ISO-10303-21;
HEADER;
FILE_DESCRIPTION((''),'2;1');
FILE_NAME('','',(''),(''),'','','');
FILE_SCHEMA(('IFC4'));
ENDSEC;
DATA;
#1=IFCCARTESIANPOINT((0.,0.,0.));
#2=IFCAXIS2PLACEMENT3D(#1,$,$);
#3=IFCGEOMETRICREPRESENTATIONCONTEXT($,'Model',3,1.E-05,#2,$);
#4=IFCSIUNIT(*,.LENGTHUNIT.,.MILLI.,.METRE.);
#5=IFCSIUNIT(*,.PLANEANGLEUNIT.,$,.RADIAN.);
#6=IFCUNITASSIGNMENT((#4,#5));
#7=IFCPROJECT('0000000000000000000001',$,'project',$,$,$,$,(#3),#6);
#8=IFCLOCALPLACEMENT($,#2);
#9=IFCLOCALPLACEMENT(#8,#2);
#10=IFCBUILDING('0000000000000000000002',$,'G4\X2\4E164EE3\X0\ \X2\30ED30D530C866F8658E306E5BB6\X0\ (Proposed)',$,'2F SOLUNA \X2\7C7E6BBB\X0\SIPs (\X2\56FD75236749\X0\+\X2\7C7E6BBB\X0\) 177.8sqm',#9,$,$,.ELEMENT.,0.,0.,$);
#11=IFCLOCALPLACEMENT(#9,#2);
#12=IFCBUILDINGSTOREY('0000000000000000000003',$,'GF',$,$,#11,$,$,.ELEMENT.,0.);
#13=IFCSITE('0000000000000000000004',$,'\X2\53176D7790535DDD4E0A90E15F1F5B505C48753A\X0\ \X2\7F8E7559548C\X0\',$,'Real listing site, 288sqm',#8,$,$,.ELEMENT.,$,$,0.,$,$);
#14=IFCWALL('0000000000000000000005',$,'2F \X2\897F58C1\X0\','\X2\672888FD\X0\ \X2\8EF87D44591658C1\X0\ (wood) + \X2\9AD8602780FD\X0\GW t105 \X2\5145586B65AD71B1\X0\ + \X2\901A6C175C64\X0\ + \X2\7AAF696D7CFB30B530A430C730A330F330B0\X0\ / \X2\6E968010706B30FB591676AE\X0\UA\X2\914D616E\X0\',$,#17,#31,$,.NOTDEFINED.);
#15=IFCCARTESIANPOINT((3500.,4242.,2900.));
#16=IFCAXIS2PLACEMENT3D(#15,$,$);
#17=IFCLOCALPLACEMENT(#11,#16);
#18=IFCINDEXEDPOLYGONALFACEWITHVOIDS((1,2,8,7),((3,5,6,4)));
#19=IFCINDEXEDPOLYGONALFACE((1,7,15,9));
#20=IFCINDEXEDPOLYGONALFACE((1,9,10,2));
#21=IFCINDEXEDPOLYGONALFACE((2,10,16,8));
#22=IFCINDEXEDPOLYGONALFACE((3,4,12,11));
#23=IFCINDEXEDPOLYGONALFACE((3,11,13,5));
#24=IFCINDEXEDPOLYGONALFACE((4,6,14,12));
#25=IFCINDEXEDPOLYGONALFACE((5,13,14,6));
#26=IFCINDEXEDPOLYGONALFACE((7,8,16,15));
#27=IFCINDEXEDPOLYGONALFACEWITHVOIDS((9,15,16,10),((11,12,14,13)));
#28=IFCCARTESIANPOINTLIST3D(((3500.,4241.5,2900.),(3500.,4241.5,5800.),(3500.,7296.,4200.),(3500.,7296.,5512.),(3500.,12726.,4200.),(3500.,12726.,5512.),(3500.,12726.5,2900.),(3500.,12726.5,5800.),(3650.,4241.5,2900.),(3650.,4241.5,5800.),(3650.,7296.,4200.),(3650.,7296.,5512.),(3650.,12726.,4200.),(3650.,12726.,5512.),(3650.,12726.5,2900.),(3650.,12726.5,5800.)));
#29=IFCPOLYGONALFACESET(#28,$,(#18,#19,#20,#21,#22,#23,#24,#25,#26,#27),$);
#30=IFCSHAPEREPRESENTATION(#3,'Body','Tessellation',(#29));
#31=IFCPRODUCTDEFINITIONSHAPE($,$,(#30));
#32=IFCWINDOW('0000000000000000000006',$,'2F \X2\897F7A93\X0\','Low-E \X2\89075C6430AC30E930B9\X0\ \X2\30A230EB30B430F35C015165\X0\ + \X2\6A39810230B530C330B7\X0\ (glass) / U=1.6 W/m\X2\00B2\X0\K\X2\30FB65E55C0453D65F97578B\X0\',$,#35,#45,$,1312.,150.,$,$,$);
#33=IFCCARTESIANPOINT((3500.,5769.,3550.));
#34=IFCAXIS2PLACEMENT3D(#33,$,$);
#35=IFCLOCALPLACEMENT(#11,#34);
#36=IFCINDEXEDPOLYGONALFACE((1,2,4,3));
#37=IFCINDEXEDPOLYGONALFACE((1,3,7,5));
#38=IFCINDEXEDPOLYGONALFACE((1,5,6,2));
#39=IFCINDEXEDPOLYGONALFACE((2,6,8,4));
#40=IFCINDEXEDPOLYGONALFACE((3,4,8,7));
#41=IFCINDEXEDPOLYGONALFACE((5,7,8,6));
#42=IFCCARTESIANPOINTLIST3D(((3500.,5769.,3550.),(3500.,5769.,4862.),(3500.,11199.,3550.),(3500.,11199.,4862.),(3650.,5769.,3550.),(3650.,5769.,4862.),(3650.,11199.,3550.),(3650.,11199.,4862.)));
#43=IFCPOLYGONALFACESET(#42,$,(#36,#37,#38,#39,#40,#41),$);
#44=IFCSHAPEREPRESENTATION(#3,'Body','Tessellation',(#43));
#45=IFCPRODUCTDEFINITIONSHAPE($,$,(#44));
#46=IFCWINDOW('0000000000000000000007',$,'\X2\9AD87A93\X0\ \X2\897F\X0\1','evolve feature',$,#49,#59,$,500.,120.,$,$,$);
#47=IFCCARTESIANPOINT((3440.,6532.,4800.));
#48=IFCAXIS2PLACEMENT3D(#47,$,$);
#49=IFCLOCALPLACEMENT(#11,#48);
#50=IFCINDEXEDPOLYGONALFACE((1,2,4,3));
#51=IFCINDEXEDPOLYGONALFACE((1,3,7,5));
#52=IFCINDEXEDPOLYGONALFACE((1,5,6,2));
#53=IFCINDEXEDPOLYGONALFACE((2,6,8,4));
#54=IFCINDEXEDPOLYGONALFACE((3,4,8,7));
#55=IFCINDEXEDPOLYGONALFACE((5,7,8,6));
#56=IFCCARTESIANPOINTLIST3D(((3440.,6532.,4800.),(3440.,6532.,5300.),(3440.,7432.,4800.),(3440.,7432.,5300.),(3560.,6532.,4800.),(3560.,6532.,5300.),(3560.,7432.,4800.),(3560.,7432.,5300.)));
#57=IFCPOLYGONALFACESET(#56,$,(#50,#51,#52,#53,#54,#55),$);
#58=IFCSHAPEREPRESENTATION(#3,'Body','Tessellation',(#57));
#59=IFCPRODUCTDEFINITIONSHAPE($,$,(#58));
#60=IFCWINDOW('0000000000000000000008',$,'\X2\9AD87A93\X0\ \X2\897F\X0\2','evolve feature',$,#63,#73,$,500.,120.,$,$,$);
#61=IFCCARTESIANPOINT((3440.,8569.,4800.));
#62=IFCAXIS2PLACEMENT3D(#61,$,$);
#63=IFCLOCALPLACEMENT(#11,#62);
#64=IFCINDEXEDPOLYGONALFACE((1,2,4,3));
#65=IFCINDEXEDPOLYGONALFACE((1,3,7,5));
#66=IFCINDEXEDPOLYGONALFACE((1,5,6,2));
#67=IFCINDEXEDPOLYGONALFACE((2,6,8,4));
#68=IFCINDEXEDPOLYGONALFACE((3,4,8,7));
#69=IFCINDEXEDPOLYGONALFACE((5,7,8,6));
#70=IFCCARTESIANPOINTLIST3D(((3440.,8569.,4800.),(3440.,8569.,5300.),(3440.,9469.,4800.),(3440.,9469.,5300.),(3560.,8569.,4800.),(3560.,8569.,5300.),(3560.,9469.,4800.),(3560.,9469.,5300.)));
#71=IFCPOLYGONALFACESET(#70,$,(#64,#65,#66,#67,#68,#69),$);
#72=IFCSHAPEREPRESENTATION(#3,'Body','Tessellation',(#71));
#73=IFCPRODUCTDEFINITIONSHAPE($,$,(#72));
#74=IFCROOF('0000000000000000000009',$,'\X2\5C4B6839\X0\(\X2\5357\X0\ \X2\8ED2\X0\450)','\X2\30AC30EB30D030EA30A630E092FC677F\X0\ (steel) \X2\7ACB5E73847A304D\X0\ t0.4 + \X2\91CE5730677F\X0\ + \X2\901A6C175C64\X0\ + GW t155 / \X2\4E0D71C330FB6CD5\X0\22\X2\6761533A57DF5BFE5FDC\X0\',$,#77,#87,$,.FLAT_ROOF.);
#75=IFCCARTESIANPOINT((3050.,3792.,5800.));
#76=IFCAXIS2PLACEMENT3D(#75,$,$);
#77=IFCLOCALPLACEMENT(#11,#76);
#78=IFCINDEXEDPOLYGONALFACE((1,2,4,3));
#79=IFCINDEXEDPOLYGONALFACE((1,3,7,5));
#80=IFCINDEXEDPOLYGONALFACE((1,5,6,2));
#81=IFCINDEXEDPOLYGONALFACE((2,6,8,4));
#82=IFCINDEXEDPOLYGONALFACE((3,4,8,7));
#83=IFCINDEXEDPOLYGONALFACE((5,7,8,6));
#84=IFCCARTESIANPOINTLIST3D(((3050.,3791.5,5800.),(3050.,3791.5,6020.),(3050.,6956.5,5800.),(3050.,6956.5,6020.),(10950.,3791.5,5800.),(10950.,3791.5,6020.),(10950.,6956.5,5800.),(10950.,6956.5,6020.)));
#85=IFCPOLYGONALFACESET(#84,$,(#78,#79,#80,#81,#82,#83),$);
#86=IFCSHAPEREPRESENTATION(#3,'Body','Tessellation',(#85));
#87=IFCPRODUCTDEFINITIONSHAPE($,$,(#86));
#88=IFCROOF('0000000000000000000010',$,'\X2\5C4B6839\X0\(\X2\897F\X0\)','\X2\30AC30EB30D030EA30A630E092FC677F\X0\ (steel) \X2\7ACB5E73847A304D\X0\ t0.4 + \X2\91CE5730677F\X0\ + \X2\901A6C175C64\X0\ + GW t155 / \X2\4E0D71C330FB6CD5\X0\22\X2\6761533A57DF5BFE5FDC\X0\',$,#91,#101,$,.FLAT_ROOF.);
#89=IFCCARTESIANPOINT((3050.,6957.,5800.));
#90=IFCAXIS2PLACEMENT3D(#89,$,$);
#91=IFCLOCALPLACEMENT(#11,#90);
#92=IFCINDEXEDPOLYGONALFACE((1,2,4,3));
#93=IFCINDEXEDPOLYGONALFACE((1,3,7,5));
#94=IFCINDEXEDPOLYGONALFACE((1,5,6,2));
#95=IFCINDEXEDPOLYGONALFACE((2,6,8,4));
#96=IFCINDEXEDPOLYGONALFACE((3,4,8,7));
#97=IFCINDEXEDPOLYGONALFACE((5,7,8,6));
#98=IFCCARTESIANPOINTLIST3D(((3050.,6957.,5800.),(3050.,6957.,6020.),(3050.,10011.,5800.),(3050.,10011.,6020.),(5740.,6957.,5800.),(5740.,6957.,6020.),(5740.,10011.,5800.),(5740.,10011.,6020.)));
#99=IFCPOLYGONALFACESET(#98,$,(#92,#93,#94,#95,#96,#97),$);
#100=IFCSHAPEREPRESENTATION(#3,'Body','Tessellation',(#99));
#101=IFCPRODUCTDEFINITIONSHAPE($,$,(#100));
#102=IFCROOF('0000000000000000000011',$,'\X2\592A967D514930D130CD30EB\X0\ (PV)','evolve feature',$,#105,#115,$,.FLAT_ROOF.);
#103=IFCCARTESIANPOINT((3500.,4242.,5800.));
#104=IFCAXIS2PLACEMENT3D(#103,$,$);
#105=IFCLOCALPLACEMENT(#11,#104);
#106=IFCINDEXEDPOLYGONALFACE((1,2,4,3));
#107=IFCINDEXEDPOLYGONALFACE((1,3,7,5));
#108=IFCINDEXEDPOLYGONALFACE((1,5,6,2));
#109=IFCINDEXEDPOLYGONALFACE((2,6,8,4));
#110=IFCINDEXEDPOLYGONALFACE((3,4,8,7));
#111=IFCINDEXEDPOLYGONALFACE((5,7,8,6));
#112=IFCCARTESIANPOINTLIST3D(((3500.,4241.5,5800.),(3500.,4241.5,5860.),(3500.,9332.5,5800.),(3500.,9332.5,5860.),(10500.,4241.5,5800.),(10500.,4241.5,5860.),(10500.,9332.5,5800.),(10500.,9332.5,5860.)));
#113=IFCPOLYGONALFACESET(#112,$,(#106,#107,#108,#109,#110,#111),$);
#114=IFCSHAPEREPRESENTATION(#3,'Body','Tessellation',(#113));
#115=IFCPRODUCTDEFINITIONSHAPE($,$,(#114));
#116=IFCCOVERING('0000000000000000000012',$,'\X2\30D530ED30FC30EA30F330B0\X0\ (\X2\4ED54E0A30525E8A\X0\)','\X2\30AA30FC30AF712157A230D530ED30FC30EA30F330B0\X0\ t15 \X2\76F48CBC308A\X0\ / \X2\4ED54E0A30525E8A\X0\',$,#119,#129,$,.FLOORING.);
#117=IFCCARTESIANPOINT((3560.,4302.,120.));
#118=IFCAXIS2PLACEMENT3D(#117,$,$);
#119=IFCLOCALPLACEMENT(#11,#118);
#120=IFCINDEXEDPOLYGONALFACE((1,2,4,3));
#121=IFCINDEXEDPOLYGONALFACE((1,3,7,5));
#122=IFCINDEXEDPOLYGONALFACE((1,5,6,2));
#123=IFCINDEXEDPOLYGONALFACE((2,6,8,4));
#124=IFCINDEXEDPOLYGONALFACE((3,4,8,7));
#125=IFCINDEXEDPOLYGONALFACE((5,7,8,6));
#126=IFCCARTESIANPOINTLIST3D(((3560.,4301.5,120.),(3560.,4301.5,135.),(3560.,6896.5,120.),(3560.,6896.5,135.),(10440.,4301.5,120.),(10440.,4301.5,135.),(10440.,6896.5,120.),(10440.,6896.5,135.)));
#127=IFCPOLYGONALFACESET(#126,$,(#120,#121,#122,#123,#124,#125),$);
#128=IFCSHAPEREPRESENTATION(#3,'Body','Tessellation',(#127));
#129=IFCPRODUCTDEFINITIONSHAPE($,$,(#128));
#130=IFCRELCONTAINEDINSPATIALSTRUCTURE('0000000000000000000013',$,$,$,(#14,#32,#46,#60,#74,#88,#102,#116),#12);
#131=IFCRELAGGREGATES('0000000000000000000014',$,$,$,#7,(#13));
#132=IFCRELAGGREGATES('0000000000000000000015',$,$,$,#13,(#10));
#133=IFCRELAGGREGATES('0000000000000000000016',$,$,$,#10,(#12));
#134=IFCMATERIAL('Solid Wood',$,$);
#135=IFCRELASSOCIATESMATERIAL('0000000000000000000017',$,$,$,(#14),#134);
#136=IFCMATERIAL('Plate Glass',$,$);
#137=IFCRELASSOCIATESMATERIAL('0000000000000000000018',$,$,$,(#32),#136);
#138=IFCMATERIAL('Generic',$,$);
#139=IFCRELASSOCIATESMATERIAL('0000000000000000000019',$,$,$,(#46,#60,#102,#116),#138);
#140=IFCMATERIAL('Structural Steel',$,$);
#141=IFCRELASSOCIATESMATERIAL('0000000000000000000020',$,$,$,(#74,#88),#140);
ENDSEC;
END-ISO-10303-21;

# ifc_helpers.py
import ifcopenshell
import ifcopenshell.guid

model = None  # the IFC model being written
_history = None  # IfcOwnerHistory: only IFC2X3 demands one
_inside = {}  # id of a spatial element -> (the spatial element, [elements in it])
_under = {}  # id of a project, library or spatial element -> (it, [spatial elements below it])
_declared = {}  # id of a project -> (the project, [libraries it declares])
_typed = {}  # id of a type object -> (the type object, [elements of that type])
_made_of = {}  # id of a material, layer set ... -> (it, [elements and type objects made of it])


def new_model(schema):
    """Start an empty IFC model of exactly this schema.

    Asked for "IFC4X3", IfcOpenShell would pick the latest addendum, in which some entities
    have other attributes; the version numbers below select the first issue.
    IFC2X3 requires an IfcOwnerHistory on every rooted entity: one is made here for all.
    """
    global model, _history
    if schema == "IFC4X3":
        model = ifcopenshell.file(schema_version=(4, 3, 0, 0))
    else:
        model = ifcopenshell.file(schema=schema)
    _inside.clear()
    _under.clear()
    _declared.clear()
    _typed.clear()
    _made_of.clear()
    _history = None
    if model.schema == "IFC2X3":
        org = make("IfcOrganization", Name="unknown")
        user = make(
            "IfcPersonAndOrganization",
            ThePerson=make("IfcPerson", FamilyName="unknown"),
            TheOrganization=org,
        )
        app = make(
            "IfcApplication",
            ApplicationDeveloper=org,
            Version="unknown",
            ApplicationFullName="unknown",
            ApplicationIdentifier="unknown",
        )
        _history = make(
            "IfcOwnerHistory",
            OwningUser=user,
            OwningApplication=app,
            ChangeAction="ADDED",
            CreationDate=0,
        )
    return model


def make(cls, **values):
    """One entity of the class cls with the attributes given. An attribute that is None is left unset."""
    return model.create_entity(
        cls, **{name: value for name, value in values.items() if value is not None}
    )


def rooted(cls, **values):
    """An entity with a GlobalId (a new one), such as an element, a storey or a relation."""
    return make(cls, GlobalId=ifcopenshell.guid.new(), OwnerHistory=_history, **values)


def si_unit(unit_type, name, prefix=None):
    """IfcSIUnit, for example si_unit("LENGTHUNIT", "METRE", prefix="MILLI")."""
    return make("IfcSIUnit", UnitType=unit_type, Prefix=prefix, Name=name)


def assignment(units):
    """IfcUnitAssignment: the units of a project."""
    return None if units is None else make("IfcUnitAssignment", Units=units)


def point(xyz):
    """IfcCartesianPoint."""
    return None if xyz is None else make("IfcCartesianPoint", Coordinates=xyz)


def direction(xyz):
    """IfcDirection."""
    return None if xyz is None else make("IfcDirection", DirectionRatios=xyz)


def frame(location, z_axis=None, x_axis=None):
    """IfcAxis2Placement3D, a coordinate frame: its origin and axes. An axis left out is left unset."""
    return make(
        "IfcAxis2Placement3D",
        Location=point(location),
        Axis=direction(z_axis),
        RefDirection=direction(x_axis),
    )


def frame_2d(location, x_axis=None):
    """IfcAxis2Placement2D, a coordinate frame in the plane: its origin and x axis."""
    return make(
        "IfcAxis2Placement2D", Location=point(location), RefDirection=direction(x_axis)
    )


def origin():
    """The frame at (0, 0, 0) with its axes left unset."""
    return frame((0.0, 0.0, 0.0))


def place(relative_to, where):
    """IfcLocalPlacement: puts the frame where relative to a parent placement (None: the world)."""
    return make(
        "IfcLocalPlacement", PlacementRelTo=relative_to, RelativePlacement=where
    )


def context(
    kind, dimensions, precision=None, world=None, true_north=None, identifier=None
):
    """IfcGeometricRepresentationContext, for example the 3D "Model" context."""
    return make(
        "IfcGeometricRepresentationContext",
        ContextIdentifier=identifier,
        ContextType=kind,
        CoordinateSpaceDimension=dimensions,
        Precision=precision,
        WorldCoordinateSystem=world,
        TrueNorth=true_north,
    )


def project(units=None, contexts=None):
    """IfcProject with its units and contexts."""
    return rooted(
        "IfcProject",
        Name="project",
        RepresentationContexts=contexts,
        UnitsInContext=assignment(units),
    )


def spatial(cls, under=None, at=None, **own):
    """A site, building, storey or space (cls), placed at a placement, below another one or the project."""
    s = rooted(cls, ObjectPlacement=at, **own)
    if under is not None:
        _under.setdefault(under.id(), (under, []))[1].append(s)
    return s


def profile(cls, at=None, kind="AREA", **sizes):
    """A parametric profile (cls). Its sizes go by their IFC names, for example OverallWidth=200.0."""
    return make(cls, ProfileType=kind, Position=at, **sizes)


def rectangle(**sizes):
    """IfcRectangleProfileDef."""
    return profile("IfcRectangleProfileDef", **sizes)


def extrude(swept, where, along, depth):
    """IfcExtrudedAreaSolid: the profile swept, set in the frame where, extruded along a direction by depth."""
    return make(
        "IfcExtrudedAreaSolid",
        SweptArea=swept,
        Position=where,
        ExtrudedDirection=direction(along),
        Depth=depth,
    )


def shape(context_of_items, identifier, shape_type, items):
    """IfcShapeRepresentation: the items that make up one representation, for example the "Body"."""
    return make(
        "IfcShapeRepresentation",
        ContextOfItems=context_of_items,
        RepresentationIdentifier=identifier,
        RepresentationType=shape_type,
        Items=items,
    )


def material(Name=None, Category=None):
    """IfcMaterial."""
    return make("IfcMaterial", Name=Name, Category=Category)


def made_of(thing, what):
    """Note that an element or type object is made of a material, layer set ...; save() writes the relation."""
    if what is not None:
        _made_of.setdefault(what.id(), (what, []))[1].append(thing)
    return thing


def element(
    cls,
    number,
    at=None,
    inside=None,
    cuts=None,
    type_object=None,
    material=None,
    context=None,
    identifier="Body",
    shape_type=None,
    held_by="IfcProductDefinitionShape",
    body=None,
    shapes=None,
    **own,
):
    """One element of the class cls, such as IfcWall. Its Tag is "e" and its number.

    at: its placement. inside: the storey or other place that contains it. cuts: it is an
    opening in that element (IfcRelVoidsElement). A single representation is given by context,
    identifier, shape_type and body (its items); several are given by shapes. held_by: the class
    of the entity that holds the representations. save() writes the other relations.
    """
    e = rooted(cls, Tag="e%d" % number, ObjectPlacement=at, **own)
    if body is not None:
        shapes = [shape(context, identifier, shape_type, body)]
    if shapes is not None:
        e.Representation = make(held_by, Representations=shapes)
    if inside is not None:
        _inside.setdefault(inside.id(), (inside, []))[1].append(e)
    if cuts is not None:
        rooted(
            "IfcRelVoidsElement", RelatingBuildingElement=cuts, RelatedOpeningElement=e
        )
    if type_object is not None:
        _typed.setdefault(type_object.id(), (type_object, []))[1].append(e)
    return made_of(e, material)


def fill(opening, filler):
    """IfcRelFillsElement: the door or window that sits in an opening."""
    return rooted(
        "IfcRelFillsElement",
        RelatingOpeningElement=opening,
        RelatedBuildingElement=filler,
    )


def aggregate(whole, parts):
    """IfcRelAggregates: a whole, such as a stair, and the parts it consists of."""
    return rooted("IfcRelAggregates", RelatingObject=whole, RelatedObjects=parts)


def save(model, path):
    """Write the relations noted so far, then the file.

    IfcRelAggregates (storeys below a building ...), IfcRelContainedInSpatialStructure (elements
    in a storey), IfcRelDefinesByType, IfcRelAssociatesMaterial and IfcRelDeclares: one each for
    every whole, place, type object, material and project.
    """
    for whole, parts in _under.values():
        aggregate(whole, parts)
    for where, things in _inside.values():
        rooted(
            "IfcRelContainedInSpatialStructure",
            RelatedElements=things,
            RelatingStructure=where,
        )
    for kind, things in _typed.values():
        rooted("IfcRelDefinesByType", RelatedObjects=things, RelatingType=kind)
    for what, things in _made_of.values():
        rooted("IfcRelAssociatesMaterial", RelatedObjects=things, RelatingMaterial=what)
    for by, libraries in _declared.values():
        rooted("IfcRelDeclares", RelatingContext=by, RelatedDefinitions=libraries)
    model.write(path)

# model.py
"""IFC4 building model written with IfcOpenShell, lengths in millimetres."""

from ifc_helpers import new_model, si_unit, frame, frame_2d, origin, place, context, project, spatial, rectangle, extrude, material, element, fill, save


model = new_model("IFC4")

# Units and contexts
model_context = context("Model", 3, precision=1e-05, world=origin())
ifc_project = project(units=[si_unit("LENGTHUNIT", "METRE", prefix="MILLI"), si_unit("PLANEANGLEUNIT", "RADIAN")], contexts=[model_context])

# Site, building, storey
site_placement = place(None, origin())
site = spatial("IfcSite", under=ifc_project, at=site_placement, Name="北海道川上郡弟子屈町 美留和", ObjectType="Real listing site, 288sqm", CompositionType="ELEMENT", RefElevation=0.0)
building_placement = place(site_placement, origin())
building = spatial("IfcBuilding", under=site, at=building_placement, Name="G4世代 ロフト書斎の家 (Proposed)", ObjectType="2F SOLUNA 籾殻SIPs (国産杉+籾殻) 177.8sqm", CompositionType="ELEMENT", ElevationOfRefHeight=0.0, ElevationOfTerrain=0.0)
storey_placement = place(building_placement, origin())
storey = spatial("IfcBuildingStorey", under=building, at=storey_placement, Name="GF", CompositionType="ELEMENT", Elevation=0.0)

# Shared definitions
ifc_material_1 = material(Name="Solid Wood")
ifc_material_2 = material(Name="Generic")

# Shared definitions
ifc_material_3 = material(Name="Plate Glass")

# Wall, openings, windows
wall_1_placement = place(storey_placement, frame((3500.0, 4242.0, 2900.0)))
wall_1 = element("IfcWall", 1, at=wall_1_placement, inside=storey, material=ifc_material_1, Name="2F 西壁", Description="木製 軸組外壁 (wood) + 高性能GW t105 充填断熱 + 通気層 + 窯業系サイディング / 準耐火・外皮UA配慮", PredefinedType="NOTDEFINED", context=model_context, shape_type="SweptSolid", body=[
    extrude(rectangle(XDim=150.0, YDim=8485.0, at=frame_2d((75.0, 4242.0))), frame((3500.0, 4242.0, 2900.0)), (0.0, 0.0, 1.0), 2900.0),
])
opening_1_placement = place(storey_placement, frame((3500.0, 5769.0, 3550.0)))
opening_1 = element("IfcOpeningElement", 2, at=opening_1_placement, cuts=wall_1, PredefinedType="NOTDEFINED", context=model_context, shape_type="SweptSolid", body=[
    extrude(rectangle(XDim=150.0, YDim=5430.0, at=frame_2d((75.0, 2715.0))), frame((3500.0, 5769.0, 3550.0)), (0.0, 0.0, 1.0), 1312.0),
])
opening_2_placement = place(storey_placement, frame((3440.0, 6532.0, 4800.0)))
opening_2 = element("IfcOpeningElement", 3, at=opening_2_placement, cuts=wall_1, PredefinedType="NOTDEFINED", context=model_context, shape_type="SweptSolid", body=[
    extrude(rectangle(XDim=120.0, YDim=900.0, at=frame_2d((60.0, 450.0))), frame((3440.0, 6532.0, 4800.0)), (0.0, 0.0, 1.0), 500.0),
])
opening_3_placement = place(storey_placement, frame((3440.0, 8569.0, 4800.0)))
opening_3 = element("IfcOpeningElement", 4, at=opening_3_placement, cuts=wall_1, PredefinedType="NOTDEFINED", context=model_context, shape_type="SweptSolid", body=[
    extrude(rectangle(XDim=120.0, YDim=900.0, at=frame_2d((60.0, 450.0))), frame((3440.0, 8569.0, 4800.0)), (0.0, 0.0, 1.0), 500.0),
])
window_1_placement = place(storey_placement, frame((3500.0, 5769.0, 3550.0)))
window_1 = element("IfcWindow", 5, at=window_1_placement, inside=storey, material=ifc_material_3, Name="2F 西窓", Description="Low-E 複層ガラス アルゴン封入 + 樹脂サッシ (glass) / U=1.6 W/m²K・日射取得型", OverallHeight=1312.0, OverallWidth=150.0, context=model_context, shape_type="SweptSolid", body=[
    extrude(rectangle(XDim=150.0, YDim=5430.0, at=frame_2d((75.0, 2715.0))), frame((3500.0, 5769.0, 3550.0)), (0.0, 0.0, 1.0), 1312.0),
])
fill(opening_1, window_1)
window_2_placement = place(storey_placement, frame((3440.0, 6532.0, 4800.0)))
window_2 = element("IfcWindow", 6, at=window_2_placement, inside=storey, material=ifc_material_2, Name="高窓 西1", Description="evolve feature", OverallHeight=500.0, OverallWidth=120.0, context=model_context, shape_type="SweptSolid", body=[
    extrude(rectangle(XDim=120.0, YDim=900.0, at=frame_2d((60.0, 450.0))), frame((3440.0, 6532.0, 4800.0)), (0.0, 0.0, 1.0), 500.0),
])
fill(opening_2, window_2)
window_3_placement = place(storey_placement, frame((3440.0, 8569.0, 4800.0)))
window_3 = element("IfcWindow", 7, at=window_3_placement, inside=storey, material=ifc_material_2, Name="高窓 西2", Description="evolve feature", OverallHeight=500.0, OverallWidth=120.0, context=model_context, shape_type="SweptSolid", body=[
    extrude(rectangle(XDim=120.0, YDim=900.0, at=frame_2d((60.0, 450.0))), frame((3440.0, 8569.0, 4800.0)), (0.0, 0.0, 1.0), 500.0),
])
fill(opening_3, window_3)

# Roofs
ifc_material_4 = material(Name="Structural Steel")
roof_1_placement = place(storey_placement, frame((3050.0, 3792.0, 5800.0)))
element("IfcRoof", 8, at=roof_1_placement, inside=storey, material=ifc_material_4, Name="屋根(南 軒450)", Description="ガルバリウム鋼板 (steel) 立平葺き t0.4 + 野地板 + 通気層 + GW t155 / 不燃・法22条区域対応", PredefinedType="FLAT_ROOF", context=model_context, shape_type="SweptSolid", body=[
    extrude(rectangle(XDim=7900.0, YDim=3165.0, at=frame_2d((3950.0, 1582.0))), frame((3050.0, 3792.0, 5800.0)), (0.0, 0.0, 1.0), 220.0),
])
roof_2_placement = place(storey_placement, frame((3050.0, 6957.0, 5800.0)))
element("IfcRoof", 9, at=roof_2_placement, inside=storey, material=ifc_material_4, Name="屋根(西)", Description="ガルバリウム鋼板 (steel) 立平葺き t0.4 + 野地板 + 通気層 + GW t155 / 不燃・法22条区域対応", PredefinedType="FLAT_ROOF", context=model_context, shape_type="SweptSolid", body=[
    extrude(rectangle(XDim=2690.0, YDim=3054.0, at=frame_2d((1345.0, 1527.0))), frame((3050.0, 6957.0, 5800.0)), (0.0, 0.0, 1.0), 220.0),
])
roof_3_placement = place(storey_placement, frame((3500.0, 4242.0, 5800.0)))
element("IfcRoof", 10, at=roof_3_placement, inside=storey, material=ifc_material_2, Name="太陽光パネル (PV)", Description="evolve feature", PredefinedType="FLAT_ROOF", context=model_context, shape_type="SweptSolid", body=[
    extrude(rectangle(XDim=7000.0, YDim=5091.0, at=frame_2d((3500.0, 2545.0))), frame((3500.0, 4242.0, 5800.0)), (0.0, 0.0, 1.0), 60.0),
])

# Covering
covering_placement = place(storey_placement, frame((3560.0, 4302.0, 120.0)))
element("IfcCovering", 11, at=covering_placement, inside=storey, material=ifc_material_2, Name="フローリング (仕上げ床)", Description="オーク無垢フローリング t15 直貼り / 仕上げ床", PredefinedType="FLOORING", context=model_context, shape_type="SweptSolid", body=[
    extrude(rectangle(XDim=6880.0, YDim=2595.0, at=frame_2d((3440.0, 1297.0))), frame((3560.0, 4302.0, 120.0)), (0.0, 0.0, 1.0), 15.0),
])

save(model, "model.ifc")
